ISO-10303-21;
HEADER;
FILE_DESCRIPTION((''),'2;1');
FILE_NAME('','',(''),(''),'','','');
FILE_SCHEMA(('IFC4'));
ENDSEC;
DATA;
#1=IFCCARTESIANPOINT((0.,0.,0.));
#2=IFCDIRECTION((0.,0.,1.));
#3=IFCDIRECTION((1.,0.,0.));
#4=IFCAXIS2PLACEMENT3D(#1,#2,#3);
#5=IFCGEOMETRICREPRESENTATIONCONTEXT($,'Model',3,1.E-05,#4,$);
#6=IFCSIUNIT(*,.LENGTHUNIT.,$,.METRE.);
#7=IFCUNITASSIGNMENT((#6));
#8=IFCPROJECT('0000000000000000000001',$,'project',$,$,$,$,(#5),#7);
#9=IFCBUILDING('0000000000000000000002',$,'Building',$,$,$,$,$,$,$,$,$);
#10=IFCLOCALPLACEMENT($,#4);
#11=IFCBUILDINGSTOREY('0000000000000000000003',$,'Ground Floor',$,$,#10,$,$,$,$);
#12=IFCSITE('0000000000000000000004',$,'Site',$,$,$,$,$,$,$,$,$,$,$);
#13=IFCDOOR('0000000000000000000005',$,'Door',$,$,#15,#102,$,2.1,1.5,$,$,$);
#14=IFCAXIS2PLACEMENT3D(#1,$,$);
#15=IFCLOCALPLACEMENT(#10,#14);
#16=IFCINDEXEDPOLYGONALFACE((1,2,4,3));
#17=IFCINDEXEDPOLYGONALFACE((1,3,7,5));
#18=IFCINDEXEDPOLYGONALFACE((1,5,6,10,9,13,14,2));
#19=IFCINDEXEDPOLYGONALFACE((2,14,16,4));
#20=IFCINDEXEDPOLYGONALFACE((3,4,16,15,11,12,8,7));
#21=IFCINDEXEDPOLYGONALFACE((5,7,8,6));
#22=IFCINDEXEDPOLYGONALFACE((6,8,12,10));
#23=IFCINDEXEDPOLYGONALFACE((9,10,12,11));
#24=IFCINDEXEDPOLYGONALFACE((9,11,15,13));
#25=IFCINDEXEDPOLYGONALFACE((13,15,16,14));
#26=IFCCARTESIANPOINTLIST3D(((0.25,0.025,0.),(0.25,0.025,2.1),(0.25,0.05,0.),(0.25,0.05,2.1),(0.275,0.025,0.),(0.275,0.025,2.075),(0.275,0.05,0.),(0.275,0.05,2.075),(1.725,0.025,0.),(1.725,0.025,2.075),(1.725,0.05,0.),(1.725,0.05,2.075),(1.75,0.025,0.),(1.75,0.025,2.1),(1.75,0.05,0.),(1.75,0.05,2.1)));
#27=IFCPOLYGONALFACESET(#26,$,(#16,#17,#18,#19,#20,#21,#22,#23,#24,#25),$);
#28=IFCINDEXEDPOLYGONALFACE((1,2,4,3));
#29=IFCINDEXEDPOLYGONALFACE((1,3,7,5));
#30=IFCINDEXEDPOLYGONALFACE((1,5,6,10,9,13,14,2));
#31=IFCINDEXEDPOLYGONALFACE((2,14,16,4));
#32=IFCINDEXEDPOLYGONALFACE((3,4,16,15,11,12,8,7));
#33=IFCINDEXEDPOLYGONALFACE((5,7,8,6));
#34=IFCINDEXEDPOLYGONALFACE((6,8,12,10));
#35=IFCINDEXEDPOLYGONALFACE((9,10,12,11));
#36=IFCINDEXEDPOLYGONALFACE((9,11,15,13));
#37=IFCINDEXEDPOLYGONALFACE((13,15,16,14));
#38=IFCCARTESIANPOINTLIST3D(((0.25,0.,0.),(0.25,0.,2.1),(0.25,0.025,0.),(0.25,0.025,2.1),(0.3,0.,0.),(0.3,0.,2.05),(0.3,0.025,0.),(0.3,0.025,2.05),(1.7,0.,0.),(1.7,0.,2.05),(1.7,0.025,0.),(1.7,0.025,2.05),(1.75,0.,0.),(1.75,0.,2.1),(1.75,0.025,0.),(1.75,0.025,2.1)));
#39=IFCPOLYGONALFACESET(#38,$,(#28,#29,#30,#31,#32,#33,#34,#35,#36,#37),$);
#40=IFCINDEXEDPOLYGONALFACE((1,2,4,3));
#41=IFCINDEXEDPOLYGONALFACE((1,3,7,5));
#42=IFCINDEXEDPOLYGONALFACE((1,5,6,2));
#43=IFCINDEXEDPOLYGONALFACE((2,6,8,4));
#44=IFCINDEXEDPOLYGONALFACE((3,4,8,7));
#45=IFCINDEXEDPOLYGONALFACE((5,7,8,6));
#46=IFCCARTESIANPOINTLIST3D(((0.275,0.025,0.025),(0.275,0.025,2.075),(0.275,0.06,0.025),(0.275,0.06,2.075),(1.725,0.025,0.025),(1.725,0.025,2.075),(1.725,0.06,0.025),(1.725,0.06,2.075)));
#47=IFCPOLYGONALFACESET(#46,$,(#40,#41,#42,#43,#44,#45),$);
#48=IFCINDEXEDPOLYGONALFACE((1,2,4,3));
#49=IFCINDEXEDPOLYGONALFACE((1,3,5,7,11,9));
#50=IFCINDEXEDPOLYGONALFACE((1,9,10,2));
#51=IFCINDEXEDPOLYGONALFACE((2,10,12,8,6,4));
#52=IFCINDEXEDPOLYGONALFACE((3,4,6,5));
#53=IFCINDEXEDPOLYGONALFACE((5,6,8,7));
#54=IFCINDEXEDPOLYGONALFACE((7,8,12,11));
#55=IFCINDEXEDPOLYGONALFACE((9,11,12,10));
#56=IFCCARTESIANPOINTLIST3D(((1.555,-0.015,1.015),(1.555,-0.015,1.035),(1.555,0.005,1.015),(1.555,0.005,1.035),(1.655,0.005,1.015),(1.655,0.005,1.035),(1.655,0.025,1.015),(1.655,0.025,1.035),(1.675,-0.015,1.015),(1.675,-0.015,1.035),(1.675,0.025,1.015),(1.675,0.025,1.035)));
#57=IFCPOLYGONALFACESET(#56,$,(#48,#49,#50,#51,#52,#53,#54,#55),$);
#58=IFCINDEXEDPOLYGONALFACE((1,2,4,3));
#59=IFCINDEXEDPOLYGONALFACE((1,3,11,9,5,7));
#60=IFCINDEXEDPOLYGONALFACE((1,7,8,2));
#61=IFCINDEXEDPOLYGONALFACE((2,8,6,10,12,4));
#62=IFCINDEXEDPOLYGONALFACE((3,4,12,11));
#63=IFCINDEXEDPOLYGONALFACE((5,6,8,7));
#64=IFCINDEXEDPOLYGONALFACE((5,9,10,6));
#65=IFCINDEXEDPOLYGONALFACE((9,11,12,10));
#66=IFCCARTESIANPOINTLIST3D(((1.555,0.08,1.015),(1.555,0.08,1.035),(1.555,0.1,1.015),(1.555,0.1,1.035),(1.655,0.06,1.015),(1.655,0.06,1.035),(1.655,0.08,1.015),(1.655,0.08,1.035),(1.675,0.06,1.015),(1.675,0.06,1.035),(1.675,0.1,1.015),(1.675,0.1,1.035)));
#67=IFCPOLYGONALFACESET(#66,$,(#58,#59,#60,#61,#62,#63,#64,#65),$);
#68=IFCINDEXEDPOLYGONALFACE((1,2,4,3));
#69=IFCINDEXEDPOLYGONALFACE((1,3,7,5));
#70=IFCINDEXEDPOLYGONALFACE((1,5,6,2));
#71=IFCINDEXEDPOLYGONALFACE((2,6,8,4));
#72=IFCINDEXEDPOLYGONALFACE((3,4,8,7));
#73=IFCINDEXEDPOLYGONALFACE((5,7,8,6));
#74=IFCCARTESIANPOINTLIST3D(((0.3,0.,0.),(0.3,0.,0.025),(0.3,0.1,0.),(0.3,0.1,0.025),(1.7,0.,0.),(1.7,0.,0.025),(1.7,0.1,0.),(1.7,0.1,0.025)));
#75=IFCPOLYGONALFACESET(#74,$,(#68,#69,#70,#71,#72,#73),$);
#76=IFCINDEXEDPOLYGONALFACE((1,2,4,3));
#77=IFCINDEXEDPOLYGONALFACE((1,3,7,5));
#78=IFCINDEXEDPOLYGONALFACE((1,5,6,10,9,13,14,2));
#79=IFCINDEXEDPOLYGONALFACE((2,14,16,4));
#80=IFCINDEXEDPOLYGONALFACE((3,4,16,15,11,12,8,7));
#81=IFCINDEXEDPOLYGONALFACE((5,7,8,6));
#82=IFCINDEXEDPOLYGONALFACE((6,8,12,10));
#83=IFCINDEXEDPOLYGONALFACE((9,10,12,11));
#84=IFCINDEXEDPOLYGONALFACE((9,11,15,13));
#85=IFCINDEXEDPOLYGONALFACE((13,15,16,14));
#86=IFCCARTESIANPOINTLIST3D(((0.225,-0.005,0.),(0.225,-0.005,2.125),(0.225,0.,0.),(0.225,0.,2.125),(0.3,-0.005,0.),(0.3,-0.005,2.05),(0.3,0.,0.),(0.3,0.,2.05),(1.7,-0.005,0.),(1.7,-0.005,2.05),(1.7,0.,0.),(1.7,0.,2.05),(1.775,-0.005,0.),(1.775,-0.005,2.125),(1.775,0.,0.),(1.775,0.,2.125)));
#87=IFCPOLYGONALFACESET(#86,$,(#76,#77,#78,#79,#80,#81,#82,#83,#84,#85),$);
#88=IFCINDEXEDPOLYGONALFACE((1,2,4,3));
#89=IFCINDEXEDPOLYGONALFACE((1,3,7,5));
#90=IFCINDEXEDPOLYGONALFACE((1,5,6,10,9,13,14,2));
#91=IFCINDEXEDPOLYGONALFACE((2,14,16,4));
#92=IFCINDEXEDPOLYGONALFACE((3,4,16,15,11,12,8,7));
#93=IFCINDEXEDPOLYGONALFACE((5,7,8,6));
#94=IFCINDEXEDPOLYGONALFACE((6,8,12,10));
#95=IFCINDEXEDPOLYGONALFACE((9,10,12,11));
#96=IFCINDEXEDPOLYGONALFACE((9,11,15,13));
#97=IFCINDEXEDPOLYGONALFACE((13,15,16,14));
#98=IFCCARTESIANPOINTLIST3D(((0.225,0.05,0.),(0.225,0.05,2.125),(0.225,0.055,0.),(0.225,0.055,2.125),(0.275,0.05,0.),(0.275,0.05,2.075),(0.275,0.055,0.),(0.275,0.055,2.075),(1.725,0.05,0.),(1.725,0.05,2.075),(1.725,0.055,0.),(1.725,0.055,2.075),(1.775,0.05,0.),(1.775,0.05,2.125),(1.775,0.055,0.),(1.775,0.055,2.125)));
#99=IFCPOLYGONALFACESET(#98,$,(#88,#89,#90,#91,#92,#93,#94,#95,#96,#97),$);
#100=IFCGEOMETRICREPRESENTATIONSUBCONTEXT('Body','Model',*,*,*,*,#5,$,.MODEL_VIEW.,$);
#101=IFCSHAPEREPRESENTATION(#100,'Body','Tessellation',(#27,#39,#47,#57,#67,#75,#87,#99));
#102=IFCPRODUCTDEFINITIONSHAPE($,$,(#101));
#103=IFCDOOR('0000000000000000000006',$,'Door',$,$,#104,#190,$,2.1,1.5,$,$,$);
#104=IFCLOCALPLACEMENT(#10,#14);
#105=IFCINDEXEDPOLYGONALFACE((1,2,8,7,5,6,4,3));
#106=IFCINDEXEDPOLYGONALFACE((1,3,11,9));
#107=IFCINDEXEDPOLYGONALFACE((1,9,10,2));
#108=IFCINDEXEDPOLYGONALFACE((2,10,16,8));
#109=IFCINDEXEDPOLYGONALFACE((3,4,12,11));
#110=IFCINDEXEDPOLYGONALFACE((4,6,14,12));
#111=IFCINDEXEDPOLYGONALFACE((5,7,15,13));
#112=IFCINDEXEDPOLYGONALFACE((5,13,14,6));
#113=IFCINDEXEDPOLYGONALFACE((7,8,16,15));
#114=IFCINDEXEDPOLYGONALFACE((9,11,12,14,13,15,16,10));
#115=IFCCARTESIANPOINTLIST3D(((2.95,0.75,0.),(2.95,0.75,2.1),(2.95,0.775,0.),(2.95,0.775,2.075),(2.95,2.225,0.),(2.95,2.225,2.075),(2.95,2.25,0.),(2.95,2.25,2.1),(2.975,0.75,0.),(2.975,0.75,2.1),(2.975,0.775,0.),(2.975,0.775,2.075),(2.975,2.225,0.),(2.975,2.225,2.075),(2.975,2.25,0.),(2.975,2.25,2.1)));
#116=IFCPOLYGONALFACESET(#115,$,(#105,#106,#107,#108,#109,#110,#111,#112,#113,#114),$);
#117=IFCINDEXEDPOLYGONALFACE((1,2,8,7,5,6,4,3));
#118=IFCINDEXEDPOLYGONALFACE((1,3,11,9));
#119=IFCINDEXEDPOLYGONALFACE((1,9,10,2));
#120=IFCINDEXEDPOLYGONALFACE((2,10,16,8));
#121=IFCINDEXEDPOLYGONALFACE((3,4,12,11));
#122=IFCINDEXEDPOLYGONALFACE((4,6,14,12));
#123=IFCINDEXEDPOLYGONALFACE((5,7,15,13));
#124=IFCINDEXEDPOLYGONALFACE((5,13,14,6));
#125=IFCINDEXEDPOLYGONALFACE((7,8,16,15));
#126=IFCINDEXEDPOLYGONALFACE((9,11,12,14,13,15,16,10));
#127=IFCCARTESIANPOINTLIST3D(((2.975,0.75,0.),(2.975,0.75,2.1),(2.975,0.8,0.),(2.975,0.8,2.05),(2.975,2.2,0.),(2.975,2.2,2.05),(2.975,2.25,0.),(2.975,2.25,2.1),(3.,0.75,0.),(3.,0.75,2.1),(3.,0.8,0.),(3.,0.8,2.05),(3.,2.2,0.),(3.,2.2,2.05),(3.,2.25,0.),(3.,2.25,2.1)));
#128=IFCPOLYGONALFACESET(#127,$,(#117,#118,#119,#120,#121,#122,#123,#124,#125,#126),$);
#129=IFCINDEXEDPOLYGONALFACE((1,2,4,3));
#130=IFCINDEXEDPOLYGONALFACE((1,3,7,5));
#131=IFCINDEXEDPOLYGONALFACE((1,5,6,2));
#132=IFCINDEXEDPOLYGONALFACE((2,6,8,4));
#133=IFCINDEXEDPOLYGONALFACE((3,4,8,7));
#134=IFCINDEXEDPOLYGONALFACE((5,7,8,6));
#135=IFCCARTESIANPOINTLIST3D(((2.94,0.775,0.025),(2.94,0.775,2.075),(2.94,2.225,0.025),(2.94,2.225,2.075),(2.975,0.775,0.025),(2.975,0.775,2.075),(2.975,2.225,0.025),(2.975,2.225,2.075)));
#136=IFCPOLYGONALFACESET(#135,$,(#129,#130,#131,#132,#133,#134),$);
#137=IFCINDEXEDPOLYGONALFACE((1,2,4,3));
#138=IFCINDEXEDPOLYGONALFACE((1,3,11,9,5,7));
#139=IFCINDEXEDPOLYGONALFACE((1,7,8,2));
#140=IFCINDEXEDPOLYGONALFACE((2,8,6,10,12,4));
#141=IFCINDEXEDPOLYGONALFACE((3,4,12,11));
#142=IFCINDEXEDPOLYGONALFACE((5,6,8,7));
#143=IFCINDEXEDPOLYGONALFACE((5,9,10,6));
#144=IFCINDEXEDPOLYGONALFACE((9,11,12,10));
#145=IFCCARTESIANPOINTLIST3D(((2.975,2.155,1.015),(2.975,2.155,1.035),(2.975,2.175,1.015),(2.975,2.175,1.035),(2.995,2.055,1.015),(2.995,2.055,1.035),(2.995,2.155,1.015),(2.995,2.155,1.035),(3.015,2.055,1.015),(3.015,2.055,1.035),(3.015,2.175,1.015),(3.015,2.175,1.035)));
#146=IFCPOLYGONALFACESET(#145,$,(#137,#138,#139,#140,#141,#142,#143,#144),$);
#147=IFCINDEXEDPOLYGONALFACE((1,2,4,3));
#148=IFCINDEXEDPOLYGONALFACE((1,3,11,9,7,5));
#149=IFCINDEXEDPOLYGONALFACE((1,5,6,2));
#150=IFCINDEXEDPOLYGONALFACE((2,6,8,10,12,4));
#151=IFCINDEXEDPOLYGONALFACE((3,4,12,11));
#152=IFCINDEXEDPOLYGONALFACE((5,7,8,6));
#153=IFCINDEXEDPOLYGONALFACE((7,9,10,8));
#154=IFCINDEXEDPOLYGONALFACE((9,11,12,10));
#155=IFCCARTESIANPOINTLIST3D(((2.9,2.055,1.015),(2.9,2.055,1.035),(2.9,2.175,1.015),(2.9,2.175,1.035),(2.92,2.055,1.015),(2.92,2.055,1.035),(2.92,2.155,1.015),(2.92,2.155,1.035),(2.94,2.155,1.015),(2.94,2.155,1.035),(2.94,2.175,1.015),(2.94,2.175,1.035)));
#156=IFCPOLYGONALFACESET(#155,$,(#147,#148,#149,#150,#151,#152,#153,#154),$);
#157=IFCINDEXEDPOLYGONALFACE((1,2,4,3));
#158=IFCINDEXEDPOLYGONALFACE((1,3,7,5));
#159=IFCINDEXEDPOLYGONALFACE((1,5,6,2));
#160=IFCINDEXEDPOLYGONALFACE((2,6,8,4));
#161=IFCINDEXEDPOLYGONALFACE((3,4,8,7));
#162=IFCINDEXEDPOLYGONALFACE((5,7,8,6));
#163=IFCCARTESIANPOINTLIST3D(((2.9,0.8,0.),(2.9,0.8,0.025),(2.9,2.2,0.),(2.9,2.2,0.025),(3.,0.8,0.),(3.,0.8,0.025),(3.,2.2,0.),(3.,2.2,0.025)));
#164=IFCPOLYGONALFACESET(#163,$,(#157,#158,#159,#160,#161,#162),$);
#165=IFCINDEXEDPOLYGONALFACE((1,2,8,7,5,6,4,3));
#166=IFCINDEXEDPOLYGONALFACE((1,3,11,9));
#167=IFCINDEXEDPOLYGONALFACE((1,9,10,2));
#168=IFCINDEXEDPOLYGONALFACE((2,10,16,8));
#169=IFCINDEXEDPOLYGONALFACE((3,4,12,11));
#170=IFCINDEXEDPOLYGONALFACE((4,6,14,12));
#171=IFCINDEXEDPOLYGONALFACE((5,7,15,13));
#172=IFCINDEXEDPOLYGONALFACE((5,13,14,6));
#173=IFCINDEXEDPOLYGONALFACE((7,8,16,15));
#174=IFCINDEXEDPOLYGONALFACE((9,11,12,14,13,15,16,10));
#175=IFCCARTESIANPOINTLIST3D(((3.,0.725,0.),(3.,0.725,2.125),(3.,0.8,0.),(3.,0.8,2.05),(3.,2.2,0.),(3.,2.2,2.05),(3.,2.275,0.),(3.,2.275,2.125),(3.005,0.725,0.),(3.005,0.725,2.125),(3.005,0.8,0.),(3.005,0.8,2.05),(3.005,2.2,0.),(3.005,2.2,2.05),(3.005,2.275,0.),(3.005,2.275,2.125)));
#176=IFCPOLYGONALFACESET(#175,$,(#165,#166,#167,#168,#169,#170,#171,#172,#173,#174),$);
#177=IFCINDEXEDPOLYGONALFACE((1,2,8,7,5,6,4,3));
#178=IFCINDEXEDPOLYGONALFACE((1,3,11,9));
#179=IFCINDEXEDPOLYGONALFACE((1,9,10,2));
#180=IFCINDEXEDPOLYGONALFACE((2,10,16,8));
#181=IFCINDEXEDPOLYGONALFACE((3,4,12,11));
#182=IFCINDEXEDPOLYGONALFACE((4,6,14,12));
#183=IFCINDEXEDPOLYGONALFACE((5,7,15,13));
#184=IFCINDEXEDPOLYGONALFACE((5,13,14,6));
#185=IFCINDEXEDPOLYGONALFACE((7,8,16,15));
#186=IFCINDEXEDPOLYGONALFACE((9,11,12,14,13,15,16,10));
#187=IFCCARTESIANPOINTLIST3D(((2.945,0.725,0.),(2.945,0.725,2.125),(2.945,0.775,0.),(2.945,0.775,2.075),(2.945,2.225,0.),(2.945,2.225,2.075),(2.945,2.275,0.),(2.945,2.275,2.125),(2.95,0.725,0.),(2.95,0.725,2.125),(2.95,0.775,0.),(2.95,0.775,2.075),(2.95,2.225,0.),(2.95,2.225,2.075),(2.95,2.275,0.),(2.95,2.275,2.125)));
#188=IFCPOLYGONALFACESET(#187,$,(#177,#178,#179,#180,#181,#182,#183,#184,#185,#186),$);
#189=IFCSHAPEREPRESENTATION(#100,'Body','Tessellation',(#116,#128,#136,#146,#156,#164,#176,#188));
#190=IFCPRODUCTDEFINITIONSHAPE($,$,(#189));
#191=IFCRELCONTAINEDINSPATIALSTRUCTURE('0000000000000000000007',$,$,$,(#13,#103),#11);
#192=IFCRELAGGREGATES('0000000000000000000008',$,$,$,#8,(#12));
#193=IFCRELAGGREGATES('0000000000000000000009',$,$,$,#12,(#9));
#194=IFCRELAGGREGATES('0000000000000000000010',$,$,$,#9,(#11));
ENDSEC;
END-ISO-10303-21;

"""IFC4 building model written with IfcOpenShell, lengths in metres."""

from ifc_helpers import new_model, si_unit, frame, origin_with_axes, place, context, subcontext, project, spatial, line, indexed_curve, outline, extrude, element, save


model = new_model("IFC4")

# Units and contexts
model_context = context("Model", 3, precision=1e-05, world=origin_with_axes())
body_context = subcontext(model_context, "Body", "Model", "MODEL_VIEW")
ifc_project = project(units=[si_unit("LENGTHUNIT", "METRE")], contexts=[model_context])

# Site, building, storey
site = spatial("IfcSite", under=ifc_project, Name="Site")
building = spatial("IfcBuilding", under=site, Name="Building")
storey_placement = place(None, origin_with_axes())
storey = spatial("IfcBuildingStorey", under=building, at=storey_placement, Name="Ground Floor")

# Doors
door_1_placement = place(storey_placement, frame((0.25, 0.0, 0.0), z_axis=(0.0, 0.0, 1.0), x_axis=(1.0, 0.0, 0.0)))
element("IfcDoor", 1, at=door_1_placement, inside=storey, Name="Door", OverallHeight=2.1, OverallWidth=1.5, context=body_context, shape_type="SweptSolid", body=[
    extrude(outline(indexed_curve([(0.0, 0.0), (0.0, 2.1), (1.5, 2.1), (1.5, 0.0), (1.475, 0.0), (1.475, 2.075), (0.025, 2.075), (0.025, 0.0)], segments=[line(1, 2, 3, 4, 5, 6, 7, 8, 1)])), frame((0.0, 0.025, 0.0), z_axis=(0.0, -1.0, 0.0), x_axis=(1.0, 0.0, 0.0)), (0.0, 0.0, -1.0), 0.025),
    extrude(outline(indexed_curve([(0.0, 0.0), (0.0, 2.1), (1.5, 2.1), (1.5, 0.0), (1.45, 0.0), (1.45, 2.05), (0.05, 2.05), (0.05, 0.0)], segments=[line(1, 2, 3, 4, 5, 6, 7, 8, 1)])), frame((0.0, 0.0, 0.0), z_axis=(0.0, -1.0, 0.0), x_axis=(1.0, 0.0, 0.0)), (0.0, 0.0, -1.0), 0.025),
    extrude(outline(indexed_curve([(0.0, 0.0), (1.45, 0.0), (1.45, 0.035), (0.0, 0.035)], segments=[line(1, 2, 3, 4, 1)])), frame((0.025, 0.025, 0.025), z_axis=(0.0, 0.0, 1.0), x_axis=(1.0, 0.0, 0.0)), (0.0, 0.0, 1.0), 2.05),
    extrude(outline(indexed_curve([(0.0, 0.0), (0.0, -0.04), (-0.12, -0.04), (-0.12, -0.02), (-0.02, -0.02), (-0.02, 0.0)], segments=[line(1, 2, 3, 4, 5, 6, 1)])), frame((1.425, 0.025, 1.015), z_axis=(0.0, 0.0, 1.0), x_axis=(1.0, 0.0, 0.0)), (0.0, 0.0, 1.0), 0.02),
    extrude(outline(indexed_curve([(0.0, 0.0), (0.0, 0.04), (-0.12, 0.04), (-0.12, 0.02), (-0.02, 0.02), (-0.02, 0.0)], segments=[line(1, 2, 3, 4, 5, 6, 1)])), frame((1.425, 0.06, 1.015), z_axis=(0.0, 0.0, 1.0), x_axis=(1.0, 0.0, 0.0)), (0.0, 0.0, 1.0), 0.02),
    extrude(outline(indexed_curve([(0.0, 0.0), (1.4, 0.0), (1.4, 0.1), (0.0, 0.1)], segments=[line(1, 2, 3, 4, 1)])), frame((0.05, 0.0, 0.0), z_axis=(0.0, 0.0, 1.0), x_axis=(1.0, 0.0, 0.0)), (0.0, 0.0, 1.0), 0.025),
    extrude(outline(indexed_curve([(0.0, 0.0), (0.0, 2.125), (1.55, 2.125), (1.55, 0.0), (1.475, 0.0), (1.475, 2.05), (0.075, 2.05), (0.075, 0.0)], segments=[line(1, 2, 3, 4, 5, 6, 7, 8, 1)])), frame((-0.025, -0.005, 0.0), z_axis=(0.0, -1.0, 0.0), x_axis=(1.0, 0.0, 0.0)), (0.0, 0.0, -1.0), 0.005),
    extrude(outline(indexed_curve([(0.0, 0.0), (0.0, 2.125), (1.55, 2.125), (1.55, 0.0), (1.5, 0.0), (1.5, 2.075), (0.05, 2.075), (0.05, 0.0)], segments=[line(1, 2, 3, 4, 5, 6, 7, 8, 1)])), frame((-0.025, 0.05, 0.0), z_axis=(0.0, -1.0, 0.0), x_axis=(1.0, 0.0, 0.0)), (0.0, 0.0, -1.0), 0.005),
])
door_2_placement = place(storey_placement, frame((3.0, 0.75, 0.0), z_axis=(0.0, 0.0, 1.0), x_axis=(0.0, 1.0, 0.0)))
element("IfcDoor", 2, at=door_2_placement, inside=storey, Name="Door", OverallHeight=2.1, OverallWidth=1.5, context=body_context, shape_type="SweptSolid", body=[
    extrude(outline(indexed_curve([(0.0, 0.0), (0.0, 2.1), (1.5, 2.1), (1.5, 0.0), (1.475, 0.0), (1.475, 2.075), (0.025, 2.075), (0.025, 0.0)], segments=[line(1, 2, 3, 4, 5, 6, 7, 8, 1)])), frame((0.0, 0.025, 0.0), z_axis=(0.0, -1.0, 0.0), x_axis=(1.0, 0.0, 0.0)), (0.0, 0.0, -1.0), 0.025),
    extrude(outline(indexed_curve([(0.0, 0.0), (0.0, 2.1), (1.5, 2.1), (1.5, 0.0), (1.45, 0.0), (1.45, 2.05), (0.05, 2.05), (0.05, 0.0)], segments=[line(1, 2, 3, 4, 5, 6, 7, 8, 1)])), frame((0.0, 0.0, 0.0), z_axis=(0.0, -1.0, 0.0), x_axis=(1.0, 0.0, 0.0)), (0.0, 0.0, -1.0), 0.025),
    extrude(outline(indexed_curve([(0.0, 0.0), (1.45, 0.0), (1.45, 0.035), (0.0, 0.035)], segments=[line(1, 2, 3, 4, 1)])), frame((0.025, 0.025, 0.025), z_axis=(0.0, 0.0, 1.0), x_axis=(1.0, 0.0, 0.0)), (0.0, 0.0, 1.0), 2.05),
    extrude(outline(indexed_curve([(0.0, 0.0), (0.0, -0.04), (-0.12, -0.04), (-0.12, -0.02), (-0.02, -0.02), (-0.02, 0.0)], segments=[line(1, 2, 3, 4, 5, 6, 1)])), frame((1.425, 0.025, 1.015), z_axis=(0.0, 0.0, 1.0), x_axis=(1.0, 0.0, 0.0)), (0.0, 0.0, 1.0), 0.02),
    extrude(outline(indexed_curve([(0.0, 0.0), (0.0, 0.04), (-0.12, 0.04), (-0.12, 0.02), (-0.02, 0.02), (-0.02, 0.0)], segments=[line(1, 2, 3, 4, 5, 6, 1)])), frame((1.425, 0.06, 1.015), z_axis=(0.0, 0.0, 1.0), x_axis=(1.0, 0.0, 0.0)), (0.0, 0.0, 1.0), 0.02),
    extrude(outline(indexed_curve([(0.0, 0.0), (1.4, 0.0), (1.4, 0.1), (0.0, 0.1)], segments=[line(1, 2, 3, 4, 1)])), frame((0.05, 0.0, 0.0), z_axis=(0.0, 0.0, 1.0), x_axis=(1.0, 0.0, 0.0)), (0.0, 0.0, 1.0), 0.025),
    extrude(outline(indexed_curve([(0.0, 0.0), (0.0, 2.125), (1.55, 2.125), (1.55, 0.0), (1.475, 0.0), (1.475, 2.05), (0.075, 2.05), (0.075, 0.0)], segments=[line(1, 2, 3, 4, 5, 6, 7, 8, 1)])), frame((-0.025, -0.005, 0.0), z_axis=(0.0, -1.0, 0.0), x_axis=(1.0, 0.0, 0.0)), (0.0, 0.0, -1.0), 0.005),
    extrude(outline(indexed_curve([(0.0, 0.0), (0.0, 2.125), (1.55, 2.125), (1.55, 0.0), (1.5, 0.0), (1.5, 2.075), (0.05, 2.075), (0.05, 0.0)], segments=[line(1, 2, 3, 4, 5, 6, 7, 8, 1)])), frame((-0.025, 0.05, 0.0), z_axis=(0.0, -1.0, 0.0), x_axis=(1.0, 0.0, 0.0)), (0.0, 0.0, -1.0), 0.005),
])

save(model, "model.ifc")
